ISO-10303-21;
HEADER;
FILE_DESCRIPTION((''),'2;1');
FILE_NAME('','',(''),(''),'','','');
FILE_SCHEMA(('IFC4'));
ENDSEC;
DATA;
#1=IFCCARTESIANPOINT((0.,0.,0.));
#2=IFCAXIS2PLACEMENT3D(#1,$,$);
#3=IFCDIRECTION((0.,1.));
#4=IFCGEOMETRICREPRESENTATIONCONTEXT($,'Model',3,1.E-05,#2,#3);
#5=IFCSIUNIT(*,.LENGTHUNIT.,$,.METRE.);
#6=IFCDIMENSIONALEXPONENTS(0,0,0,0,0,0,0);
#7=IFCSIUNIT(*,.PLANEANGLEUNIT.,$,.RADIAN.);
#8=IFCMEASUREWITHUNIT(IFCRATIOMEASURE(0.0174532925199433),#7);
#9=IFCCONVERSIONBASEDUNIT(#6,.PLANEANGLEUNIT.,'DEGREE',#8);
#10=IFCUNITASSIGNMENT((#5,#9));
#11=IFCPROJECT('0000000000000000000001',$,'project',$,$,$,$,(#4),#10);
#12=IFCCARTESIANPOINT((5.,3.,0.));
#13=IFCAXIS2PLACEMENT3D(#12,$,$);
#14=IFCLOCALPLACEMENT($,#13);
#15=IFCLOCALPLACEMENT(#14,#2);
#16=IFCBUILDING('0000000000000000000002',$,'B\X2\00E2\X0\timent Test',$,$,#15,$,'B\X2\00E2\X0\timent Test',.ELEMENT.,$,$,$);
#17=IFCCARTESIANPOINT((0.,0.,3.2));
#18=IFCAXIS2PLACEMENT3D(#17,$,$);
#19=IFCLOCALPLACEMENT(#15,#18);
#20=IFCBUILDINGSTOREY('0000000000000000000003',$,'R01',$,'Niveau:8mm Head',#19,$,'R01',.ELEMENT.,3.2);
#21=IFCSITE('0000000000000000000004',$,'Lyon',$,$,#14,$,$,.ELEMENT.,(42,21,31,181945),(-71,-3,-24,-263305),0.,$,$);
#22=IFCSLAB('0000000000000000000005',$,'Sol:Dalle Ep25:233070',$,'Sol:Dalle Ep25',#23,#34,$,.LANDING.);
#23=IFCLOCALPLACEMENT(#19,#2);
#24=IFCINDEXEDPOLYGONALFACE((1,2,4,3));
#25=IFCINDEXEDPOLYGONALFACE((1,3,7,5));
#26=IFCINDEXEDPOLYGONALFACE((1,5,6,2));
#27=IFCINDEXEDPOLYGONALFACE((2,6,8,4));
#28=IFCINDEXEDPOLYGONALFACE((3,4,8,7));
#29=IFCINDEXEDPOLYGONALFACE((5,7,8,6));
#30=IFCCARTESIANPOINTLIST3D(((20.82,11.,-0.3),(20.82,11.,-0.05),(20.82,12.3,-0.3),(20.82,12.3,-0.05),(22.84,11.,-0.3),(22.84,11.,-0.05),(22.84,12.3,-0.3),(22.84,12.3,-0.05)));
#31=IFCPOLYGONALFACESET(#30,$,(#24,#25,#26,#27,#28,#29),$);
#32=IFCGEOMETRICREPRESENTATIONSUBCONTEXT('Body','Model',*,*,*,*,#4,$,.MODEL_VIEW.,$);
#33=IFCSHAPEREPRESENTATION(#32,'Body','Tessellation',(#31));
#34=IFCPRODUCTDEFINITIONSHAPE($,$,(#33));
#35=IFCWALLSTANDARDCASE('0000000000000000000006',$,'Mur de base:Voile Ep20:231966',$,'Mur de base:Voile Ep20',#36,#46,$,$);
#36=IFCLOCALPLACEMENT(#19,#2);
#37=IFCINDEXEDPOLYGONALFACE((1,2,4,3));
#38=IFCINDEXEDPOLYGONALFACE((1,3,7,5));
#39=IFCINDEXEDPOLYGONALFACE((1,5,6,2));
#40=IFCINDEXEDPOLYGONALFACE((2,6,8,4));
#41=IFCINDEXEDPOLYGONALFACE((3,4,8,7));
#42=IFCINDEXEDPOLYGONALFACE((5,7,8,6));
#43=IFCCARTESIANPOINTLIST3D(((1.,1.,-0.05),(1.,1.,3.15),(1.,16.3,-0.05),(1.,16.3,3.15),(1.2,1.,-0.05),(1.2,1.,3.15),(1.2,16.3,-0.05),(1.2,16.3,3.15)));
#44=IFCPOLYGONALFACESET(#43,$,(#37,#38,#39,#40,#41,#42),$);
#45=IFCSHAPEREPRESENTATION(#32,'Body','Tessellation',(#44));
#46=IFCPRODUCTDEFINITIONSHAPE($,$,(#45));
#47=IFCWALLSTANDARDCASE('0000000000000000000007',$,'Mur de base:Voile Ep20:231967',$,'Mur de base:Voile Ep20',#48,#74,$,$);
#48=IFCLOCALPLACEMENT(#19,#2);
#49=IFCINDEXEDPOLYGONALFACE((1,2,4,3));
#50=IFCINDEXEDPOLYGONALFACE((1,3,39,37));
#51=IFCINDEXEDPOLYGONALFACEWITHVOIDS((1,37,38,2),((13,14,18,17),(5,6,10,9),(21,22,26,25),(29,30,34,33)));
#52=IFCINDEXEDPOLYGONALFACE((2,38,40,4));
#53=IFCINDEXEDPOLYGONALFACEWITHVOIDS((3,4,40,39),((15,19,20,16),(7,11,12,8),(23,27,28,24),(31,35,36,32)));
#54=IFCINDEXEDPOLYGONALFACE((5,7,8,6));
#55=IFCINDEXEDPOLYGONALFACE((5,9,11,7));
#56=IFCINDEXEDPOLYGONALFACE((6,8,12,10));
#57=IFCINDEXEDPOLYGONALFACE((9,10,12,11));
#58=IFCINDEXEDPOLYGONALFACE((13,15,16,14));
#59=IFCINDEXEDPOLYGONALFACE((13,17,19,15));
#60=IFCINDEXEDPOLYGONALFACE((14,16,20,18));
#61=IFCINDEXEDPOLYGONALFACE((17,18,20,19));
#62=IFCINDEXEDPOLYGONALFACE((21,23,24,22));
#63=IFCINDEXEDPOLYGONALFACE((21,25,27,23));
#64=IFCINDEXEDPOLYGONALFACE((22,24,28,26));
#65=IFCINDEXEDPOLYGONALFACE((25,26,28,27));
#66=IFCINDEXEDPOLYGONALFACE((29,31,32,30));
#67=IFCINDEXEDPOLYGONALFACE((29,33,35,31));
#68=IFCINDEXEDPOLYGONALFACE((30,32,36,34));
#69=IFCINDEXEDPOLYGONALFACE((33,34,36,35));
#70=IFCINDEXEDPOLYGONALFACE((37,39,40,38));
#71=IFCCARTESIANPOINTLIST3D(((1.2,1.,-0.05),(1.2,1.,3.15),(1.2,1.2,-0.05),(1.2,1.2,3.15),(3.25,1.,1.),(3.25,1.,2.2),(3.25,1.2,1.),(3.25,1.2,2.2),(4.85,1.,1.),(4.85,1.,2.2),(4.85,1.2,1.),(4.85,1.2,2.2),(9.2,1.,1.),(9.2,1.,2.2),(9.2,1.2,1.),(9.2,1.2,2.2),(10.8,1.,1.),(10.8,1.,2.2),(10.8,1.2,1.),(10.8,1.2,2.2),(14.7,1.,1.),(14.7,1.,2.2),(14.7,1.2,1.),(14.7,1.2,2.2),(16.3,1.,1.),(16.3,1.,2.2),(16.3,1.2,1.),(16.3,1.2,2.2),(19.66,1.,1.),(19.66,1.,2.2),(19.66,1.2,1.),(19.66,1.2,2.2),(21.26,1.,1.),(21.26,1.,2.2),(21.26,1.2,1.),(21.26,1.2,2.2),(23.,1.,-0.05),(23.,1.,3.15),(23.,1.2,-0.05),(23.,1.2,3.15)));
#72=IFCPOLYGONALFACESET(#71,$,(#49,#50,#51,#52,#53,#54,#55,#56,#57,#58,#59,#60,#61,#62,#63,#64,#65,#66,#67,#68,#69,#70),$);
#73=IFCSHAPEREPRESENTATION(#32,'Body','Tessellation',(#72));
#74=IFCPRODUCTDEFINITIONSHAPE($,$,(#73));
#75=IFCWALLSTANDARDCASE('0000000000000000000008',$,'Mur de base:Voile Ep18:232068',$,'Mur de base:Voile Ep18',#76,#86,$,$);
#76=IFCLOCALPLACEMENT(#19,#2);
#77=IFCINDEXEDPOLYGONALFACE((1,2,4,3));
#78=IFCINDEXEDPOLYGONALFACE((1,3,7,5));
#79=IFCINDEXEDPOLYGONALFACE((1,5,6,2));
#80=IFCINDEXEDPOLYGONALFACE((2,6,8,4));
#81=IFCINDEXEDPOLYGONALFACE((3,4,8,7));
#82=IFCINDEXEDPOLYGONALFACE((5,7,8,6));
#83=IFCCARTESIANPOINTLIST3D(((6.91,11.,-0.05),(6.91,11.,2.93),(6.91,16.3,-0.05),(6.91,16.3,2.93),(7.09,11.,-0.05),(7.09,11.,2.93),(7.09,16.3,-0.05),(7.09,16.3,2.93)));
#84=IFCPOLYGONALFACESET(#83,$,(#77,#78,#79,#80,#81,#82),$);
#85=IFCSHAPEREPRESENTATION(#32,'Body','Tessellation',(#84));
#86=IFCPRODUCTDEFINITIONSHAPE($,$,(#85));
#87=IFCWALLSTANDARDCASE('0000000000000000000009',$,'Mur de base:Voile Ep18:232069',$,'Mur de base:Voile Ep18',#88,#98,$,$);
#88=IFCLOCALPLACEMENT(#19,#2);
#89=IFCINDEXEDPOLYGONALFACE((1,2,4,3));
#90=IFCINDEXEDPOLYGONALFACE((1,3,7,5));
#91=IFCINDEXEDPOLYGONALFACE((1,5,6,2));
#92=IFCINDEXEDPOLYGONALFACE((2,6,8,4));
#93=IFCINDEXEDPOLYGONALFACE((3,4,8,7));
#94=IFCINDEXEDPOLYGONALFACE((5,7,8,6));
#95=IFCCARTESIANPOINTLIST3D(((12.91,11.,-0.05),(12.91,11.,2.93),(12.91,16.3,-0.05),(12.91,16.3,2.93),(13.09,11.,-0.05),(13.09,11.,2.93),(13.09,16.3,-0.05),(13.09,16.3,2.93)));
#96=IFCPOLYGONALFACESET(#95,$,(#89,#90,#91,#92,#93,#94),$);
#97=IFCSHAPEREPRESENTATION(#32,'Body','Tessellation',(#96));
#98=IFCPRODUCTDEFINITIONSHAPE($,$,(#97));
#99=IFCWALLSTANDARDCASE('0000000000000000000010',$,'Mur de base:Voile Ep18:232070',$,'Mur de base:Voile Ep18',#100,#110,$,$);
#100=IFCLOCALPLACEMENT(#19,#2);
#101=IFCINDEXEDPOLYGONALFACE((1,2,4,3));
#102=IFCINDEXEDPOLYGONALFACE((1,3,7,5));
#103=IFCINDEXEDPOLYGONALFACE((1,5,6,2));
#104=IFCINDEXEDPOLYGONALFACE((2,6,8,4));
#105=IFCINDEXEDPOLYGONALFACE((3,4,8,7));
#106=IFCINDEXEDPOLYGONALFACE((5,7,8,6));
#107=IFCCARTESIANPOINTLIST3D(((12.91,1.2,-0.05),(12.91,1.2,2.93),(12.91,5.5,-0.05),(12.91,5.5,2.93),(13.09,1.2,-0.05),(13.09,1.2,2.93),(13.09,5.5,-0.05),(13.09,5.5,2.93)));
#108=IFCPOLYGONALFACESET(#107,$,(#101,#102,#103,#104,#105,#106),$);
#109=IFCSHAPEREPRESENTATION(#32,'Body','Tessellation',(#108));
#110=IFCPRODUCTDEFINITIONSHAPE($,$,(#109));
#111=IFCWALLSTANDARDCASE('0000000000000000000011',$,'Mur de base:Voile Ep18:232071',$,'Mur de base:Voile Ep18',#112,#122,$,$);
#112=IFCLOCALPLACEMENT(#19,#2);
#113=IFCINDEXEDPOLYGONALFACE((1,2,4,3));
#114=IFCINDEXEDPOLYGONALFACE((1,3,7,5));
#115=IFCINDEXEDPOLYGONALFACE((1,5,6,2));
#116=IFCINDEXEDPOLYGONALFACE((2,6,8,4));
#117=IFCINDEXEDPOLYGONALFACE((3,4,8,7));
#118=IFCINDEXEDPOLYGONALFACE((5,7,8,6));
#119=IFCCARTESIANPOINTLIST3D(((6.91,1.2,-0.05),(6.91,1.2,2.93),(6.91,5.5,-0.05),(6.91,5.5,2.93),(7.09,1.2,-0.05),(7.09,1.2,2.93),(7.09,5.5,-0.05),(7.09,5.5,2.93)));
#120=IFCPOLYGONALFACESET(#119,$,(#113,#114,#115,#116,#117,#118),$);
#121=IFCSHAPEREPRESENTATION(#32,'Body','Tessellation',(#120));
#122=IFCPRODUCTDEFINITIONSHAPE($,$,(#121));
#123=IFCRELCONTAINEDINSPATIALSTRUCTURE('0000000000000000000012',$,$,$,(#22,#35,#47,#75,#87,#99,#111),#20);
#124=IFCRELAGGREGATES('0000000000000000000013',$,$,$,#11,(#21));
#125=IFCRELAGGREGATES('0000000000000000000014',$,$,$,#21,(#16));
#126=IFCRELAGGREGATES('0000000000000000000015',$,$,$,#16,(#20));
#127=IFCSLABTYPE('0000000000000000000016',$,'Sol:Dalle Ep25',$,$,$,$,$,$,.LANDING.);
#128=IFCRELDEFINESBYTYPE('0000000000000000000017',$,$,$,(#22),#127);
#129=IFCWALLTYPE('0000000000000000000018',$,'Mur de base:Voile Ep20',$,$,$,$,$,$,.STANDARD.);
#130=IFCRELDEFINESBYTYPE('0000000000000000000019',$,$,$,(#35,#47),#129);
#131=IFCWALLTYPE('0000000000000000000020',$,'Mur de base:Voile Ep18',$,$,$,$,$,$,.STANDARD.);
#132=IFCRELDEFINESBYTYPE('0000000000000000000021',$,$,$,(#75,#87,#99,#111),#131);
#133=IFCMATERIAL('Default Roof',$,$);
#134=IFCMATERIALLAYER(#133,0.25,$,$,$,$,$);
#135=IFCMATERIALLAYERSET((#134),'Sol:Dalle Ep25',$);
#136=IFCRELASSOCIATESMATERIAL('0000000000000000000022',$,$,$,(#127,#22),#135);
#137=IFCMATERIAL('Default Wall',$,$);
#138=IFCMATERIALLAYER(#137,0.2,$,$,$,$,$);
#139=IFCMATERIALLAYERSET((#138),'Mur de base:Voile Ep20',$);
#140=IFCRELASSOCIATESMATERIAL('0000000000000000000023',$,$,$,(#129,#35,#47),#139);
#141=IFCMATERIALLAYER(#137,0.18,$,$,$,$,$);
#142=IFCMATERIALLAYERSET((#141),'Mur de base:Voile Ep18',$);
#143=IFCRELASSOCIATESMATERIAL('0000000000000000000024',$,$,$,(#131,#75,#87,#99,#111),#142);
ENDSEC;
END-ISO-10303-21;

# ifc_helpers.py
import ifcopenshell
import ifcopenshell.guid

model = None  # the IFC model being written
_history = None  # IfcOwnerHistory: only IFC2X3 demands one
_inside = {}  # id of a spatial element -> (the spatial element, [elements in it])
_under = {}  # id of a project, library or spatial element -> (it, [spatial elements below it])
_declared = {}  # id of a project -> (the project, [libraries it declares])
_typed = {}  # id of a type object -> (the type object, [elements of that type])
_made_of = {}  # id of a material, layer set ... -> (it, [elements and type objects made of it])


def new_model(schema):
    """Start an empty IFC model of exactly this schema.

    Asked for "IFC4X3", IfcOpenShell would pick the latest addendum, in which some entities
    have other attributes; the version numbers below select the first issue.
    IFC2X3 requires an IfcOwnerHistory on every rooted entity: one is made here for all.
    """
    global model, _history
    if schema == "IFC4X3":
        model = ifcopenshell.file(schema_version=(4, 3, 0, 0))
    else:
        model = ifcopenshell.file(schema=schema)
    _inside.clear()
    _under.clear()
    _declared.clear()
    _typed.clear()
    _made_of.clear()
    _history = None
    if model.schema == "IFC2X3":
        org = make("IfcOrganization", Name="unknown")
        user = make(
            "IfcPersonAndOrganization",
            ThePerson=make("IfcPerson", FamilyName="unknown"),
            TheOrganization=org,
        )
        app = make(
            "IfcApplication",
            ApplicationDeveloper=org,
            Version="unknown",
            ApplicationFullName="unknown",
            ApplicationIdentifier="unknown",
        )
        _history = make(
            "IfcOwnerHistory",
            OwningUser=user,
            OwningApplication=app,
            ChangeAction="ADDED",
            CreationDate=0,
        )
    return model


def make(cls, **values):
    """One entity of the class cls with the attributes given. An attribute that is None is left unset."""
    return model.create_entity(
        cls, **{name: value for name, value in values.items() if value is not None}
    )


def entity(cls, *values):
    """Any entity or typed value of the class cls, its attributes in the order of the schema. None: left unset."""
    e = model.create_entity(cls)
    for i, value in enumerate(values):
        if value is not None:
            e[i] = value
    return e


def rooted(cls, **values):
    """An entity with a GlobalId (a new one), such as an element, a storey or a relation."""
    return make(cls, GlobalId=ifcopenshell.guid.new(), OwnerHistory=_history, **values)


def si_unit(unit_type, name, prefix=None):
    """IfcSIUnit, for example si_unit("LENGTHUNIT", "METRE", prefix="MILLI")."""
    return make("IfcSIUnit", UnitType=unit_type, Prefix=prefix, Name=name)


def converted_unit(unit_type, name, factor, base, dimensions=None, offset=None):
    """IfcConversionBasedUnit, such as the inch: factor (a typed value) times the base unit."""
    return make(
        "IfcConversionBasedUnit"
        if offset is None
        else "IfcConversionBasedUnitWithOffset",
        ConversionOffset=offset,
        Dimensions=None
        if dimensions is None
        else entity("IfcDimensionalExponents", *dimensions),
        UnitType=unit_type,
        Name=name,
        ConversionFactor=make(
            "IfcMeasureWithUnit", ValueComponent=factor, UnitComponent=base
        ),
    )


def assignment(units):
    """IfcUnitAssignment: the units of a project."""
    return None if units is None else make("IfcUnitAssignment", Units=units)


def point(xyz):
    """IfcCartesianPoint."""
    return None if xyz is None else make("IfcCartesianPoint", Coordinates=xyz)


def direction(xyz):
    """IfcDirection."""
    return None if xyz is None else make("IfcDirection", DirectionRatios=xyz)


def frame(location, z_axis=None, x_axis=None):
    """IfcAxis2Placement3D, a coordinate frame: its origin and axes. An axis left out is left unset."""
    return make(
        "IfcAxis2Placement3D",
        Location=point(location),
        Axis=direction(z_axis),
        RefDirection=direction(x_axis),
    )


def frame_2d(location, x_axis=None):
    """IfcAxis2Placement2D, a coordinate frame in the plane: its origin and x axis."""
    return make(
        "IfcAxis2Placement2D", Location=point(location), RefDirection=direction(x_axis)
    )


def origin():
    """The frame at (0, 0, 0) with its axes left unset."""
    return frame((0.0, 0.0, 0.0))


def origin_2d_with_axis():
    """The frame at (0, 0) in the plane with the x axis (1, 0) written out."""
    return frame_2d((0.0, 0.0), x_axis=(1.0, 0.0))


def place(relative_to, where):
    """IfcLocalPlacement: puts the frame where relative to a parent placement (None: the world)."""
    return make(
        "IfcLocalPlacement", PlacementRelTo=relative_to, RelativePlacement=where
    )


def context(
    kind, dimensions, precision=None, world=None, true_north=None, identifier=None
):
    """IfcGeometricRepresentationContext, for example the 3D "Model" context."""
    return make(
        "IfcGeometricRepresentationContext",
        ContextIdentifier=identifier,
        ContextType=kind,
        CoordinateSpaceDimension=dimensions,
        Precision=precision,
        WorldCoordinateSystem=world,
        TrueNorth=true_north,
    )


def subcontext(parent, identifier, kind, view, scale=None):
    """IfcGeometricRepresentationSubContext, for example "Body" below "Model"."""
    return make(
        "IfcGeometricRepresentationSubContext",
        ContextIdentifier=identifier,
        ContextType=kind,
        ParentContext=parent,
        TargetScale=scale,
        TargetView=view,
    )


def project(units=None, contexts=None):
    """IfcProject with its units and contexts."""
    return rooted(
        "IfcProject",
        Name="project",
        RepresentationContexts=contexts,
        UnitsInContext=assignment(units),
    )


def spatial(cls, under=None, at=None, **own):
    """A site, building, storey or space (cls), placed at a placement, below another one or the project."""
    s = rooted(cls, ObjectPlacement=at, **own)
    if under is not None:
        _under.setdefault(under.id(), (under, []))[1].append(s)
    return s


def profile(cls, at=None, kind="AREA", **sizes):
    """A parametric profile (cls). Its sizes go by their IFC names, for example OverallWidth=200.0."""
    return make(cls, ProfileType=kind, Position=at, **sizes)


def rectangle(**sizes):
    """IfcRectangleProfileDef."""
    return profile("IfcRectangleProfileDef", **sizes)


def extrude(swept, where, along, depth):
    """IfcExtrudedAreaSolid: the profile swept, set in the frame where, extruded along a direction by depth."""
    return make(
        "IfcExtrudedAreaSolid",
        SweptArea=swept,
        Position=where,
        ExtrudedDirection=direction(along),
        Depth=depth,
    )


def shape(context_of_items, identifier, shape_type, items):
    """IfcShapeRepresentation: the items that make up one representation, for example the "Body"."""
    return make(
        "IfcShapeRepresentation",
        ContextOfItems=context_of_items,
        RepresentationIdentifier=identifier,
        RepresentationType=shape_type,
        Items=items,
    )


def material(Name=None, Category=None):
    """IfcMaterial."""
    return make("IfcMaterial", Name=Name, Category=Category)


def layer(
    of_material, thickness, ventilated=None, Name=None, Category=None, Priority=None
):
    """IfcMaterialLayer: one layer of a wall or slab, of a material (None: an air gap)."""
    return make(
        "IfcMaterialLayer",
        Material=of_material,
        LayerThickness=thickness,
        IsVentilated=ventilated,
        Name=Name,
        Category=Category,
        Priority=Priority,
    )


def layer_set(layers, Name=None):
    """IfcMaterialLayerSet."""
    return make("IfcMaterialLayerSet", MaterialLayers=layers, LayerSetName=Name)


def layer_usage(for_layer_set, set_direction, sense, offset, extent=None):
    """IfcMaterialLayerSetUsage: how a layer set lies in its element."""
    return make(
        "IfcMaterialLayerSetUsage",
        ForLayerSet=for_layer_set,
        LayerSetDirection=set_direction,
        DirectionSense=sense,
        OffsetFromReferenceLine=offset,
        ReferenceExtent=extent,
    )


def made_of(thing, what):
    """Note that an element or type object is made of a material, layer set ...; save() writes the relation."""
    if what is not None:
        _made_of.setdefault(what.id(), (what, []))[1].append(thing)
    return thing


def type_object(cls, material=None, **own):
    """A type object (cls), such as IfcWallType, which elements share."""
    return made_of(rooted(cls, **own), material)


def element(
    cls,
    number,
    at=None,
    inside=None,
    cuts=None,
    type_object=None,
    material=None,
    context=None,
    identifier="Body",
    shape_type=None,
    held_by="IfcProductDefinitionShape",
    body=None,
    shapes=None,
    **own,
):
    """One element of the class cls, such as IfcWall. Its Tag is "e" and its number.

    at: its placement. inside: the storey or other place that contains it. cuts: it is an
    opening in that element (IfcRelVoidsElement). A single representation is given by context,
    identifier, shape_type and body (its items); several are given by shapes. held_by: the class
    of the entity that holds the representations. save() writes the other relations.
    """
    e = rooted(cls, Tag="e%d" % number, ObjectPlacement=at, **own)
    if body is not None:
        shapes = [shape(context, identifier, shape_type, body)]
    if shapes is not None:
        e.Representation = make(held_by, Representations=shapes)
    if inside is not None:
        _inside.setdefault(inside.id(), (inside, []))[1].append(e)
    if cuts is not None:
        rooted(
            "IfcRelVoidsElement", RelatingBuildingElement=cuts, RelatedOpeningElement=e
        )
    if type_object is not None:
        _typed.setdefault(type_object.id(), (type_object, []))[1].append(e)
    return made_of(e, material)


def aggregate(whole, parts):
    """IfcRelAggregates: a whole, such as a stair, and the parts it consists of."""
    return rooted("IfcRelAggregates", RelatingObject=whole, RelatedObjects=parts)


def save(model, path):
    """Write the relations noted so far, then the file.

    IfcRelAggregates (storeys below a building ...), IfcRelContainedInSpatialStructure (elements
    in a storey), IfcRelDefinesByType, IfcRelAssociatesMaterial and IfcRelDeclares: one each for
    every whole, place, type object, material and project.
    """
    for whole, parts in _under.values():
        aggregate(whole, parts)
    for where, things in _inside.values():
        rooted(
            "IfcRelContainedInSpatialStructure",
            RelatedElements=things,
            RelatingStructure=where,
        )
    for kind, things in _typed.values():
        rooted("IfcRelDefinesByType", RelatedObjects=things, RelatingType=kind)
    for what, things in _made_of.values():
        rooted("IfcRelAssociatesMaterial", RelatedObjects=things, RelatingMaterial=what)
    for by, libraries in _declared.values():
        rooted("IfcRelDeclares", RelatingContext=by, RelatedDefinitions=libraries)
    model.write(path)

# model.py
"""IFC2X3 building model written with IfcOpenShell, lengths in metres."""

from ifc_helpers import new_model, entity, si_unit, converted_unit, direction, frame, frame_2d, origin, origin_2d_with_axis, place, context, subcontext, project, spatial, rectangle, extrude, material, layer, layer_set, layer_usage, type_object, element, save


model = new_model("IFC2X3")

# Units and contexts
model_context = context("Model", 3, precision=1e-05, world=origin(), true_north=direction((0.0, 1.0)))
body_context = subcontext(model_context, "Body", "Model", "MODEL_VIEW")
ifc_project = project(units=[si_unit("LENGTHUNIT", "METRE"), converted_unit("PLANEANGLEUNIT", "DEGREE", entity("IfcRatioMeasure", 0.0174532925199433), si_unit("PLANEANGLEUNIT", "RADIAN"), dimensions=[0, 0, 0, 0, 0, 0, 0])], contexts=[model_context])

# Site, building, storey
site_placement = place(None, frame((5.0, 3.0, 0.0)))
site = spatial("IfcSite", under=ifc_project, at=site_placement, Name="Lyon", CompositionType="ELEMENT", RefLatitude=(42, 21, 31, 181945), RefLongitude=(-71, -3, -24, -263305), RefElevation=0.0)
building_placement = place(site_placement, origin())
building = spatial("IfcBuilding", under=site, at=building_placement, Name="Bâtiment Test", LongName="Bâtiment Test", CompositionType="ELEMENT")
storey_placement = place(building_placement, frame((0.0, 0.0, 3.2)))
storey = spatial("IfcBuildingStorey", under=building, at=storey_placement, Name="R01", ObjectType="Niveau:8mm Head", LongName="R01", CompositionType="ELEMENT", Elevation=3.2)

# Slab
ifc_material_1 = material(Name="Default Roof")
ifc_layer_1 = layer(ifc_material_1, 0.25)
ifc_layer_set_1 = layer_set([ifc_layer_1], Name="Sol:Dalle Ep25")
ifc_layer_usage_1 = layer_usage(ifc_layer_set_1, "AXIS3", "POSITIVE", 0.0)
slab_type_1 = type_object("IfcSlabType", Name="Sol:Dalle Ep25", PredefinedType="LANDING", material=ifc_layer_set_1)
slab_1_placement = place(storey_placement, origin())
element("IfcSlab", 1, at=slab_1_placement, inside=storey, type_object=slab_type_1, material=ifc_layer_usage_1, Name="Sol:Dalle Ep25:233070", ObjectType="Sol:Dalle Ep25", PredefinedType="LANDING", context=body_context, shape_type="SweptSolid", body=[
    extrude(rectangle(XDim=1.3, YDim=2.02, at=frame_2d((0.0, 0.0), x_axis=(1.0, 0.0))), frame((21.83, 11.65, -0.05), z_axis=(0.0, 0.0, -1.0), x_axis=(0.0, 1.0, 0.0)), (0.0, 0.0, 1.0), 0.25),
])

# Wall
ifc_material_2 = material(Name="Default Wall")
ifc_layer_2 = layer(ifc_material_2, 0.2)
ifc_layer_set_2 = layer_set([ifc_layer_2], Name="Mur de base:Voile Ep20")
ifc_layer_usage_2 = layer_usage(ifc_layer_set_2, "AXIS2", "POSITIVE", -0.1)
wall_type_1 = type_object("IfcWallType", Name="Mur de base:Voile Ep20", PredefinedType="STANDARD", material=ifc_layer_set_2)
wall_1_placement = place(storey_placement, frame((1.1, 16.3, -0.05), z_axis=(0.0, 0.0, 1.0), x_axis=(0.0, -1.0, 0.0)))
element("IfcWallStandardCase", 2, at=wall_1_placement, inside=storey, type_object=wall_type_1, material=ifc_layer_usage_2, Name="Mur de base:Voile Ep20:231966", ObjectType="Mur de base:Voile Ep20", context=body_context, shape_type="SweptSolid", body=[
    extrude(rectangle(XDim=15.3, YDim=0.2, at=frame_2d((7.65, 0.0), x_axis=(-1.0, 0.0))), origin(), (0.0, 0.0, 1.0), 3.2),
])

# Wall, openings
ifc_layer_usage_3 = layer_usage(ifc_layer_set_2, "AXIS2", "POSITIVE", -0.1)
wall_2_placement = place(storey_placement, frame((1.2, 1.1, -0.05)))
wall_2 = element("IfcWallStandardCase", 3, at=wall_2_placement, inside=storey, type_object=wall_type_1, material=ifc_layer_usage_3, Name="Mur de base:Voile Ep20:231967", ObjectType="Mur de base:Voile Ep20", context=body_context, shape_type="SweptSolid", body=[
    extrude(rectangle(XDim=21.8, YDim=0.2, at=frame_2d((10.9, 0.0), x_axis=(-1.0, 0.0))), origin(), (0.0, 0.0, 1.0), 3.2),
])
opening_1_placement = place(wall_2_placement, origin())
element("IfcOpeningElement", 4, at=opening_1_placement, cuts=wall_2, ObjectType="Opening", context=body_context, shape_type="SweptSolid", body=[
    extrude(rectangle(XDim=1.2, YDim=1.6, at=frame_2d((0.0, 0.0), x_axis=(0.0, 1.0))), frame((2.85, -0.1, 1.65), z_axis=(0.0, 1.0, 0.0), x_axis=(1.0, 0.0, 0.0)), (0.0, 0.0, 1.0), 0.2),
])
opening_2_placement = place(wall_2_placement, origin())
element("IfcOpeningElement", 5, at=opening_2_placement, cuts=wall_2, ObjectType="Opening", context=body_context, shape_type="SweptSolid", body=[
    extrude(rectangle(XDim=1.2, YDim=1.6, at=origin_2d_with_axis()), frame((8.8, -0.1, 1.65), z_axis=(0.0, 1.0, 0.0), x_axis=(0.0, 0.0, -1.0)), (0.0, 0.0, 1.0), 0.2),
])
opening_3_placement = place(wall_2_placement, origin())
element("IfcOpeningElement", 6, at=opening_3_placement, cuts=wall_2, ObjectType="Opening", context=body_context, shape_type="SweptSolid", body=[
    extrude(rectangle(XDim=1.2, YDim=1.6, at=frame_2d((0.0, 0.0), x_axis=(0.0, 1.0))), frame((14.3, -0.1, 1.65), z_axis=(0.0, 1.0, 0.0), x_axis=(1.0, 0.0, 0.0)), (0.0, 0.0, 1.0), 0.2),
])
opening_4_placement = place(wall_2_placement, origin())
element("IfcOpeningElement", 7, at=opening_4_placement, cuts=wall_2, ObjectType="Opening", context=body_context, shape_type="SweptSolid", body=[
    extrude(rectangle(XDim=1.2, YDim=1.6, at=origin_2d_with_axis()), frame((19.26, -0.1, 1.65), z_axis=(0.0, 1.0, 0.0), x_axis=(0.0, 0.0, -1.0)), (0.0, 0.0, 1.0), 0.2),
])

# Walls
ifc_layer_3 = layer(ifc_material_2, 0.18)
ifc_layer_set_3 = layer_set([ifc_layer_3], Name="Mur de base:Voile Ep18")
ifc_layer_usage_4 = layer_usage(ifc_layer_set_3, "AXIS2", "NEGATIVE", 0.09)
wall_type_2 = type_object("IfcWallType", Name="Mur de base:Voile Ep18", PredefinedType="STANDARD", material=ifc_layer_set_3)
wall_3_placement = place(storey_placement, frame((7.0, 16.3, -0.05), z_axis=(0.0, 0.0, 1.0), x_axis=(0.0, -1.0, 0.0)))
element("IfcWallStandardCase", 8, at=wall_3_placement, inside=storey, type_object=wall_type_2, material=ifc_layer_usage_4, Name="Mur de base:Voile Ep18:232068", ObjectType="Mur de base:Voile Ep18", context=body_context, shape_type="SweptSolid", body=[
    extrude(rectangle(XDim=5.3, YDim=0.18, at=frame_2d((2.65, 0.0), x_axis=(-1.0, 0.0))), origin(), (0.0, 0.0, 1.0), 2.98),
])
ifc_layer_usage_5 = layer_usage(ifc_layer_set_3, "AXIS2", "NEGATIVE", 0.09)
wall_4_placement = place(storey_placement, frame((13.0, 16.3, -0.05), z_axis=(0.0, 0.0, 1.0), x_axis=(0.0, -1.0, 0.0)))
element("IfcWallStandardCase", 9, at=wall_4_placement, inside=storey, type_object=wall_type_2, material=ifc_layer_usage_5, Name="Mur de base:Voile Ep18:232069", ObjectType="Mur de base:Voile Ep18", context=body_context, shape_type="SweptSolid", body=[
    extrude(rectangle(XDim=5.3, YDim=0.18, at=frame_2d((2.65, 0.0), x_axis=(-1.0, 0.0))), origin(), (0.0, 0.0, 1.0), 2.98),
])
ifc_layer_usage_6 = layer_usage(ifc_layer_set_3, "AXIS2", "NEGATIVE", 0.09)
wall_5_placement = place(storey_placement, frame((13.0, 1.2, -0.05), z_axis=(0.0, 0.0, 1.0), x_axis=(0.0, 1.0, 0.0)))
element("IfcWallStandardCase", 10, at=wall_5_placement, inside=storey, type_object=wall_type_2, material=ifc_layer_usage_6, Name="Mur de base:Voile Ep18:232070", ObjectType="Mur de base:Voile Ep18", context=body_context, shape_type="SweptSolid", body=[
    extrude(rectangle(XDim=4.3, YDim=0.18, at=frame_2d((2.15, 0.0), x_axis=(-1.0, 0.0))), origin(), (0.0, 0.0, 1.0), 2.98),
])
ifc_layer_usage_7 = layer_usage(ifc_layer_set_3, "AXIS2", "NEGATIVE", 0.09)
wall_6_placement = place(storey_placement, frame((7.0, 1.2, -0.05), z_axis=(0.0, 0.0, 1.0), x_axis=(0.0, 1.0, 0.0)))
element("IfcWallStandardCase", 11, at=wall_6_placement, inside=storey, type_object=wall_type_2, material=ifc_layer_usage_7, Name="Mur de base:Voile Ep18:232071", ObjectType="Mur de base:Voile Ep18", context=body_context, shape_type="SweptSolid", body=[
    extrude(rectangle(XDim=4.3, YDim=0.18, at=frame_2d((2.15, 0.0), x_axis=(-1.0, 0.0))), origin(), (0.0, 0.0, 1.0), 2.98),
])

save(model, "model.ifc")
